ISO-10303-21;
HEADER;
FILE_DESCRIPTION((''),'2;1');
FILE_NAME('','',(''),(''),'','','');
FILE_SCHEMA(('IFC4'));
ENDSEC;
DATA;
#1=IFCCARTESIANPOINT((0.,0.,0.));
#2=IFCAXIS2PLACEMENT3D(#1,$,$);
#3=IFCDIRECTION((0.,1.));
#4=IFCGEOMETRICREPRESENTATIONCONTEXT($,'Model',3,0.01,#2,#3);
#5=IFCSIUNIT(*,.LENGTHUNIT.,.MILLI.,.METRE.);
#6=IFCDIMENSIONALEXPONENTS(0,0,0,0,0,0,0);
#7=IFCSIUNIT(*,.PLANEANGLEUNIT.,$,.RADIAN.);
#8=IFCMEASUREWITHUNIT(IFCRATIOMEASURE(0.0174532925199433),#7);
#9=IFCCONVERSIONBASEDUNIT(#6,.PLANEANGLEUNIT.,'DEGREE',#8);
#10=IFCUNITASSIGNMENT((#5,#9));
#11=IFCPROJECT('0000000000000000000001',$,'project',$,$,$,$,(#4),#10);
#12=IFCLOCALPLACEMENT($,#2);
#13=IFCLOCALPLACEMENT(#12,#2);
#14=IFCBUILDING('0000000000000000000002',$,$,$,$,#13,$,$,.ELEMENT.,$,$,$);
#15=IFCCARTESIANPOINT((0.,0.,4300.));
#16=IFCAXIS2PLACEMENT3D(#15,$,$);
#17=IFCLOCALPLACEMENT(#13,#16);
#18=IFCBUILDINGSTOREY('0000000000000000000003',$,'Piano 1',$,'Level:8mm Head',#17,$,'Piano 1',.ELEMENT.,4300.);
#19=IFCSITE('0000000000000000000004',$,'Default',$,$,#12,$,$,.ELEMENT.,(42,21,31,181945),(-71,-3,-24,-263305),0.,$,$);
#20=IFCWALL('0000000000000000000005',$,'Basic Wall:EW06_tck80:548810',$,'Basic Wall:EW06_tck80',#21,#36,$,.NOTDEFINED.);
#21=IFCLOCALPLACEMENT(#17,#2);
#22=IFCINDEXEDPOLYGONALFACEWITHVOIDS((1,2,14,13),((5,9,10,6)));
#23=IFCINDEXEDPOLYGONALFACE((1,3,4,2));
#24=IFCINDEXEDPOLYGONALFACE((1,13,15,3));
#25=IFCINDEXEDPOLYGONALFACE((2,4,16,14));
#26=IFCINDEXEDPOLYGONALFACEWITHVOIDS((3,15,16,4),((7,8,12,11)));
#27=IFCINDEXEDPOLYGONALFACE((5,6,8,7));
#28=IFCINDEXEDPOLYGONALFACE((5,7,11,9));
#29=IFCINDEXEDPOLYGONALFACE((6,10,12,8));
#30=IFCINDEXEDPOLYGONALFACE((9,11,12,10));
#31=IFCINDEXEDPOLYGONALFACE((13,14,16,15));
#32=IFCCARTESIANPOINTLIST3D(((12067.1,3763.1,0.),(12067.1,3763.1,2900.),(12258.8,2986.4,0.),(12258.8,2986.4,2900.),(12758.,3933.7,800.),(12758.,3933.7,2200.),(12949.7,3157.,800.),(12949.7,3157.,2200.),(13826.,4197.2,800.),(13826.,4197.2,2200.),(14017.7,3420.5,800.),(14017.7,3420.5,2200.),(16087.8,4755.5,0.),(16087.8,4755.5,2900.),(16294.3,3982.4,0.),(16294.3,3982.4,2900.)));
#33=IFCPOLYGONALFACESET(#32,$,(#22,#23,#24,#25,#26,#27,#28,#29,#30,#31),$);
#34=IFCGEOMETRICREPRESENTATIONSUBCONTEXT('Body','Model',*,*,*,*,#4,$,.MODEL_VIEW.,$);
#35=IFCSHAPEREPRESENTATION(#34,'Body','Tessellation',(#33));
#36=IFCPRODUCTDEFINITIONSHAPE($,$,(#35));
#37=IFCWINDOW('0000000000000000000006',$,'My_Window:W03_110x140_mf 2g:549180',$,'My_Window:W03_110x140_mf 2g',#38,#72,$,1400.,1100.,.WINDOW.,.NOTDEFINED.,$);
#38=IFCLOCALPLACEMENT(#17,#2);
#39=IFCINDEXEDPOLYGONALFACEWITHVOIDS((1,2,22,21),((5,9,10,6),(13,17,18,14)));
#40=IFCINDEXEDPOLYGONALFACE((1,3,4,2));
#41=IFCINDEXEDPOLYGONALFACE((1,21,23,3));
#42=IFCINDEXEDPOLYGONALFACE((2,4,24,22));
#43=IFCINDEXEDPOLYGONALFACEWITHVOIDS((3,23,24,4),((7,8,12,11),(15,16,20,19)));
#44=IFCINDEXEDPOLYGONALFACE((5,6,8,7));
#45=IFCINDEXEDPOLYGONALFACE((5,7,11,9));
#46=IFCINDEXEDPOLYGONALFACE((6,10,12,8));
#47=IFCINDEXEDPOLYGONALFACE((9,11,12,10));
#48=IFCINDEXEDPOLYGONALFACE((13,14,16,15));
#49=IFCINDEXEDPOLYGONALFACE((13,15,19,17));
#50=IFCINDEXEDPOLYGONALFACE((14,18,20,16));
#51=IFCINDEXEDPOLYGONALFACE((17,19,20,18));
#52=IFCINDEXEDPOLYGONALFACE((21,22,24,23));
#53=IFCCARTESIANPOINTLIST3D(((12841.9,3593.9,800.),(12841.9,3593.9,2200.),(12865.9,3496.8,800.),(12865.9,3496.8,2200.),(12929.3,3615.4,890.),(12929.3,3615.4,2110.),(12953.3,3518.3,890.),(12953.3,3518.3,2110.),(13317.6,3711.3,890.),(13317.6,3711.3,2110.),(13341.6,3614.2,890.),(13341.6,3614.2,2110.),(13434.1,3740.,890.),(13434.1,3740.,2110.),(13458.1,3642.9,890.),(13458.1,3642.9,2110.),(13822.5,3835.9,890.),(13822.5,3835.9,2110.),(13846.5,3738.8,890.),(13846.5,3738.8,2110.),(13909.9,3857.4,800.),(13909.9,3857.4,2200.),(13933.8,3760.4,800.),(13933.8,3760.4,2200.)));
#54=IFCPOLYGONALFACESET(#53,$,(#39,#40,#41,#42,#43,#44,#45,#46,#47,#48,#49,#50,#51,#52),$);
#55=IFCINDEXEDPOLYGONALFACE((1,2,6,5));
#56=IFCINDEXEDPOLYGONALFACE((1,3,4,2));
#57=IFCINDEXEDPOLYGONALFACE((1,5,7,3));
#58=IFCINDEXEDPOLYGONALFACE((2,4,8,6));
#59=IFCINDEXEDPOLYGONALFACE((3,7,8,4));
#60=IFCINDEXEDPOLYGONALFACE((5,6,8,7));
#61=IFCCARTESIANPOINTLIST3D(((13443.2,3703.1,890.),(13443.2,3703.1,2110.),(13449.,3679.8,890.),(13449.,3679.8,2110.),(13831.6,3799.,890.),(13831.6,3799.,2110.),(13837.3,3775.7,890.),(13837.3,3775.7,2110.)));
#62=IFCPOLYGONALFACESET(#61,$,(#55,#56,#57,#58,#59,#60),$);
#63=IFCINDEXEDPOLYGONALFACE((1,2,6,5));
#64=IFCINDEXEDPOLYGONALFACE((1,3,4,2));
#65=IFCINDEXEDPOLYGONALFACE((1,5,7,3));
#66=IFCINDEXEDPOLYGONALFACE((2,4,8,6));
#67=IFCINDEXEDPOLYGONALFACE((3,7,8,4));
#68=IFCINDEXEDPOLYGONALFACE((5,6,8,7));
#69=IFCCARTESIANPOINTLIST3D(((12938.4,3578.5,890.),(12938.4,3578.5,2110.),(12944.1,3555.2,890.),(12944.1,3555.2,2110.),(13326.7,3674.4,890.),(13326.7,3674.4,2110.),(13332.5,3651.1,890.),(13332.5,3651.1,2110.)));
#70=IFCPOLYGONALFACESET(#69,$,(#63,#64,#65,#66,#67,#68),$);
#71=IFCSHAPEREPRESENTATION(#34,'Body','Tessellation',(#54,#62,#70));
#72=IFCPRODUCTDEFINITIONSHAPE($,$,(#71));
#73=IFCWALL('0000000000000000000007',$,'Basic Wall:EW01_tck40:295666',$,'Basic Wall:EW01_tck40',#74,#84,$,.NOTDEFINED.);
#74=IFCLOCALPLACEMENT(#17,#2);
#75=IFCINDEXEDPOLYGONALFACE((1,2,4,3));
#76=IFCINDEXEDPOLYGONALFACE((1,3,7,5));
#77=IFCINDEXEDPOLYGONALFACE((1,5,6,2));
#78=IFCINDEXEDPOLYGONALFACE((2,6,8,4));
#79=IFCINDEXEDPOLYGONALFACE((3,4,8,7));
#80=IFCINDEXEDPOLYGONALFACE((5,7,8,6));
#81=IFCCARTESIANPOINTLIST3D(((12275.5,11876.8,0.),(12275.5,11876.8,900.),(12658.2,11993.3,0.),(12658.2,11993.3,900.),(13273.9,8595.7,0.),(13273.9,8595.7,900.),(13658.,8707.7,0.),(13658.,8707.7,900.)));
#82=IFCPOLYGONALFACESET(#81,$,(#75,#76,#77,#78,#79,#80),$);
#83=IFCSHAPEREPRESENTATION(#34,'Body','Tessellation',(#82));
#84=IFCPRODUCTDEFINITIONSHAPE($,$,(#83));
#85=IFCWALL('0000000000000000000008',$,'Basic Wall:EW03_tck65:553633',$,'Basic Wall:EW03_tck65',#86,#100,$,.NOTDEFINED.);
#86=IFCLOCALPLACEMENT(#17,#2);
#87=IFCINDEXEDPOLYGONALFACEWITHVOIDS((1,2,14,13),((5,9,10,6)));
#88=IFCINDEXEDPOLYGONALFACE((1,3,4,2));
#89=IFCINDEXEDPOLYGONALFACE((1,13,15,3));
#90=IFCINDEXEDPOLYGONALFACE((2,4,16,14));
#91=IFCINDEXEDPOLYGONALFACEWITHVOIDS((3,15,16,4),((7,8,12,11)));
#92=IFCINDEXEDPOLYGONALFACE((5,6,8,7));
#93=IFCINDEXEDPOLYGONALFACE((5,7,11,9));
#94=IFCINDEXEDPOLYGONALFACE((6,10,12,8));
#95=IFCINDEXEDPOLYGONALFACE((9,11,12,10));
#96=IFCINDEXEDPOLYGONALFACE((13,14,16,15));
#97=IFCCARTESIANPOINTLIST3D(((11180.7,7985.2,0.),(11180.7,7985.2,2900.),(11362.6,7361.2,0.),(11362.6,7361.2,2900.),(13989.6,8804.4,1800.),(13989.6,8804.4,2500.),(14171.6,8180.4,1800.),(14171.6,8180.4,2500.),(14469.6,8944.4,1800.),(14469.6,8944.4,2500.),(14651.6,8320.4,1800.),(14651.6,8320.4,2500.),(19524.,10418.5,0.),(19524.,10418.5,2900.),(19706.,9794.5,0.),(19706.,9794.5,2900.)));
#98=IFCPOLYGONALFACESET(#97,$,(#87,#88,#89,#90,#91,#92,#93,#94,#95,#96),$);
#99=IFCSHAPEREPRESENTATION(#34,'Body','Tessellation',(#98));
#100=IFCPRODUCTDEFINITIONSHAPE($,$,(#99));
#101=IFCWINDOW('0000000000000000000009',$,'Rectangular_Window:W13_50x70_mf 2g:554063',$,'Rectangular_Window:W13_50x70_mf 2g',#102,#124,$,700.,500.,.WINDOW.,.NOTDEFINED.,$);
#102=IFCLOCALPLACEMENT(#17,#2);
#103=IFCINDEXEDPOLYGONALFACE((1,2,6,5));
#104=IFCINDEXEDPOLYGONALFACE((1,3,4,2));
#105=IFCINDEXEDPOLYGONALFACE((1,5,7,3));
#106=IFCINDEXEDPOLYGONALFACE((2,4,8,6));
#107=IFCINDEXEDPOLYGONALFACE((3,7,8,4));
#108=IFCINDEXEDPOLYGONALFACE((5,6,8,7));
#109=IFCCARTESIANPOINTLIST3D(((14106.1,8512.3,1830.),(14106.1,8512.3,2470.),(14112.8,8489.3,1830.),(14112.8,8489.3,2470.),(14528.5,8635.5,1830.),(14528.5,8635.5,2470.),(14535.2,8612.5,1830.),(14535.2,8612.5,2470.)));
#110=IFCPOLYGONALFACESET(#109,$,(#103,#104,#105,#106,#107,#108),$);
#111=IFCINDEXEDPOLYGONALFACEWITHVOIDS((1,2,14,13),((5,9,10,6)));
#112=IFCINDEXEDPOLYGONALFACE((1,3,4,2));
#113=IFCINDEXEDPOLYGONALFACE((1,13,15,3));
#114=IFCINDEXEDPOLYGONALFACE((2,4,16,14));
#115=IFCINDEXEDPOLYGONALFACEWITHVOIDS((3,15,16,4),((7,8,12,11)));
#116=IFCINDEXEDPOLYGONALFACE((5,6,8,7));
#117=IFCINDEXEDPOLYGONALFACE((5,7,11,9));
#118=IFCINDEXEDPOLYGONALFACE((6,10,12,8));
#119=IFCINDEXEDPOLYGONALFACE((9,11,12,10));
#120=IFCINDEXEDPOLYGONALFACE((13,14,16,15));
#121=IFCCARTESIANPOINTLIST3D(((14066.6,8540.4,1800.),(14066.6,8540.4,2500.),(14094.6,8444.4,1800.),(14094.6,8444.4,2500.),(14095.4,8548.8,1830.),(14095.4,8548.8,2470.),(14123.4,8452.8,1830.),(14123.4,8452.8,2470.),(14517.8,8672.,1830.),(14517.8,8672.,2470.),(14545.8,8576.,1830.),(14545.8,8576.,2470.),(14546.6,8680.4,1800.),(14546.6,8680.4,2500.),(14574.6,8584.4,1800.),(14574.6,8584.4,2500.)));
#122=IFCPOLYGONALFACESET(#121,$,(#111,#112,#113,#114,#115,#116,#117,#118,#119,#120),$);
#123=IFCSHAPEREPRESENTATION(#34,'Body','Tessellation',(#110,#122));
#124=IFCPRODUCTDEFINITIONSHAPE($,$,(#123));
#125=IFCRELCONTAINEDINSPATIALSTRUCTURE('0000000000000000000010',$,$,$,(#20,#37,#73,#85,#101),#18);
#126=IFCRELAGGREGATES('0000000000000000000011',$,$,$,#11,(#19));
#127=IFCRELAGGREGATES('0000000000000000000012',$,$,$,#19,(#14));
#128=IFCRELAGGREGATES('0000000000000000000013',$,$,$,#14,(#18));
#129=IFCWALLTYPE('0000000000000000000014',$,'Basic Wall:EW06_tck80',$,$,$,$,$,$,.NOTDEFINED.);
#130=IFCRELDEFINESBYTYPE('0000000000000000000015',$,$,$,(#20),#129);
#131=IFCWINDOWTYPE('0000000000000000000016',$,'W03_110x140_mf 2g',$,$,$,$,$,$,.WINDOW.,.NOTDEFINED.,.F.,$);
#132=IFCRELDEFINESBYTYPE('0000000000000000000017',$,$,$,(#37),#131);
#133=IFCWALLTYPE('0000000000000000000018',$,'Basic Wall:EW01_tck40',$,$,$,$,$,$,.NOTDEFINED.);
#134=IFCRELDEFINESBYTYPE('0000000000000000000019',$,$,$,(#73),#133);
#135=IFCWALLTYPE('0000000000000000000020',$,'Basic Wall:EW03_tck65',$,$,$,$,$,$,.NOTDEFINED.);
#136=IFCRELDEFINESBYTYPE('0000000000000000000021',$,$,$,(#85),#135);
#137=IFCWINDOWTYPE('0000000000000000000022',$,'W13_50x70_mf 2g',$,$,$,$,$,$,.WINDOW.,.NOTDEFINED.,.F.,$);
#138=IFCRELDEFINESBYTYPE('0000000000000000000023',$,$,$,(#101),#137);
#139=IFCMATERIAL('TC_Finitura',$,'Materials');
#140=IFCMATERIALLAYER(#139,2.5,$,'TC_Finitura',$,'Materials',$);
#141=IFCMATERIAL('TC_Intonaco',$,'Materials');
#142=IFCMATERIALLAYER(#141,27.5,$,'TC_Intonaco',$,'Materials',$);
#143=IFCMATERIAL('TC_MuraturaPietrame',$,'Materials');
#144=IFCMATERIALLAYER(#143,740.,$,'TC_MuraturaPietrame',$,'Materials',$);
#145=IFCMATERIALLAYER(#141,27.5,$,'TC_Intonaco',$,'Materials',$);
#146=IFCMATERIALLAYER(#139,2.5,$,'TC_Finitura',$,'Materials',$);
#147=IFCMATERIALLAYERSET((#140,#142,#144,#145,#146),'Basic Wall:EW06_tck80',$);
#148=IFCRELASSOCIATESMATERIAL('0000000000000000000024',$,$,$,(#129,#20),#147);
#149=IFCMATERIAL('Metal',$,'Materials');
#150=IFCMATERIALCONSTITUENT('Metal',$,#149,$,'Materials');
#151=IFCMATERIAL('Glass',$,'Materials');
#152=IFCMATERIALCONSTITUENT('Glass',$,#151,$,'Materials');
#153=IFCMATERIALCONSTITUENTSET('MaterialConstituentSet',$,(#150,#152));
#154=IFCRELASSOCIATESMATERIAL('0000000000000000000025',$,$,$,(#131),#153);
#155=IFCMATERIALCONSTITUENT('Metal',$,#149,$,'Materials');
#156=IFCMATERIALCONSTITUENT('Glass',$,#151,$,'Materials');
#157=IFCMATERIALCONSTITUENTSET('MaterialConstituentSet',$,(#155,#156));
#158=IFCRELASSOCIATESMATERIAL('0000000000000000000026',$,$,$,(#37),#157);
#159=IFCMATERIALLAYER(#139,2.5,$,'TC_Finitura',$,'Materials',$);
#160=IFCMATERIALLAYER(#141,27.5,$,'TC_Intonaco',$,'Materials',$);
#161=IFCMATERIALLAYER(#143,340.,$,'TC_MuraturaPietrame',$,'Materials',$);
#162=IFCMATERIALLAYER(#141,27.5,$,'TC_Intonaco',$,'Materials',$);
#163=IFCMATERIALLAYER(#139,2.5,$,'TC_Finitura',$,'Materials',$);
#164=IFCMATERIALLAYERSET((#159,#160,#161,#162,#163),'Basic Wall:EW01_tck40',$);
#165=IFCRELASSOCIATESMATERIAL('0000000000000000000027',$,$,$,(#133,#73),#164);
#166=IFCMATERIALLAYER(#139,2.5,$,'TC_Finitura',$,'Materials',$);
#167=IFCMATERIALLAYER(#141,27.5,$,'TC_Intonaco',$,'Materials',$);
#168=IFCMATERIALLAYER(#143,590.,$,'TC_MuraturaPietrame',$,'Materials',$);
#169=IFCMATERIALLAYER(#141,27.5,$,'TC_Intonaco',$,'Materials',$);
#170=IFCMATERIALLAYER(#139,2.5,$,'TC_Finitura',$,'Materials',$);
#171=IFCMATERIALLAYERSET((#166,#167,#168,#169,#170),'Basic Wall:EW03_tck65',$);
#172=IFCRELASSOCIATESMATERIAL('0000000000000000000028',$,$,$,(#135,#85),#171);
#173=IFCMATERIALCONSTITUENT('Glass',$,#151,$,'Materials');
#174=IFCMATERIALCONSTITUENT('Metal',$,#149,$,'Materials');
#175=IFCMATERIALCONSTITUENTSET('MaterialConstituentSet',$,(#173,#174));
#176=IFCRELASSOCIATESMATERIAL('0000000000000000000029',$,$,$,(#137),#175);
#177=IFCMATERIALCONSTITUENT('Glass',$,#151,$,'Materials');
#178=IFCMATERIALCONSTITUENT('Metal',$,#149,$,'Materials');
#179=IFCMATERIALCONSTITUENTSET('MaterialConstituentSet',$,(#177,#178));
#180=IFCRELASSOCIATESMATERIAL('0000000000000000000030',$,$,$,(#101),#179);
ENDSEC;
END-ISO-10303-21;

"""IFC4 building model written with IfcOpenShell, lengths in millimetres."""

from ifc_helpers import new_model, entity, si_unit, converted_unit, direction, frame, frame_2d, origin, origin_2d_with_axis, place, context, subcontext, project, spatial, polyline, rectangle, outline, extrude, clip, bounded_halfspace, source, transform, mapped, material, layer, layer_set, layer_usage, constituent, constituent_set, type_object, type_shapes, element, fill, save


model = new_model("IFC4")

# Units and contexts
model_context = context("Model", 3, precision=0.01, world=origin(), true_north=direction((0.0, 1.0)))
body_context = subcontext(model_context, "Body", "Model", "MODEL_VIEW")
ifc_project = project(units=[si_unit("LENGTHUNIT", "METRE", prefix="MILLI"), converted_unit("PLANEANGLEUNIT", "DEGREE", entity("IfcRatioMeasure", 0.0174532925199433), si_unit("PLANEANGLEUNIT", "RADIAN"), dimensions=[0, 0, 0, 0, 0, 0, 0])], contexts=[model_context])

# Site, building, storey
site_placement = place(None, origin())
site = spatial("IfcSite", under=ifc_project, at=site_placement, Name="Default", CompositionType="ELEMENT", RefLatitude=(42, 21, 31, 181945), RefLongitude=(-71, -3, -24, -263305), RefElevation=0.0)
building_placement = place(site_placement, origin())
building = spatial("IfcBuilding", under=site, at=building_placement, CompositionType="ELEMENT")
storey_placement = place(building_placement, frame((0.0, 0.0, 4300.0)))
storey = spatial("IfcBuildingStorey", under=building, at=storey_placement, Name="Piano 1", ObjectType="Level:8mm Head", LongName="Piano 1", CompositionType="ELEMENT", Elevation=4300.0)

# Wall, opening, window
ifc_material_1 = material(Name="TC_Finitura", Category="Materials")
ifc_layer_1 = layer(ifc_material_1, 2.5, Name="TC_Finitura", Category="Materials")
ifc_material_2 = material(Name="TC_Intonaco", Category="Materials")
ifc_layer_2 = layer(ifc_material_2, 27.5, Name="TC_Intonaco", Category="Materials")
ifc_material_3 = material(Name="TC_MuraturaPietrame", Category="Materials")
ifc_layer_3 = layer(ifc_material_3, 740.0, Name="TC_MuraturaPietrame", Category="Materials")
ifc_layer_4 = layer(ifc_material_2, 27.5, Name="TC_Intonaco", Category="Materials")
ifc_layer_5 = layer(ifc_material_1, 2.5, Name="TC_Finitura", Category="Materials")
ifc_layer_set_1 = layer_set([ifc_layer_1, ifc_layer_2, ifc_layer_3, ifc_layer_4, ifc_layer_5], Name="Basic Wall:EW06_tck80")
ifc_layer_usage_1 = layer_usage(ifc_layer_set_1, "AXIS2", "NEGATIVE", 400.0)
wall_type_1 = type_object("IfcWallType", Name="Basic Wall:EW06_tck80", PredefinedType="NOTDEFINED", material=ifc_layer_set_1)
wall_1_placement = place(storey_placement, frame((16198.4, 4370.8, 0.0), z_axis=(0.0, 0.0, 1.0), x_axis=(-0.970868, -0.239617, 0.0)))
wall_1 = element("IfcWall", 1, at=wall_1_placement, inside=storey, type_object=wall_type_1, material=ifc_layer_usage_1, Name="Basic Wall:EW06_tck80:548810", ObjectType="Basic Wall:EW06_tck80", PredefinedType="NOTDEFINED", context=body_context, shape_type="Clipping", body=[
    clip(extrude(outline(polyline([(4156.6, -400.0), (4156.6, 400.0), (0.0, 400.0), (14.0, -333.4), (15.3, -400.0), (4156.6, -400.0)])), origin(), (0.0, 0.0, 1.0), 2900.0), bounded_halfspace(frame((15.3, -400.0, 2900.0), z_axis=(0.0, 0.0, -1.0), x_axis=(-0.999481, -0.032214, 0.0)), True, frame((15.3, -400.0, 2900.0)), polyline([(0.0, 0.0), (4141.3, 0.0), (4141.3, 800.0), (-15.3, 800.0), (-1.3, 66.6), (0.0, 0.0)]))),
])
opening_1_placement = place(wall_1_placement, frame((2344.9, -400.0, 800.0)))
opening_1 = element("IfcOpeningElement", 2, at=opening_1_placement, cuts=wall_1, ObjectType="Opening", PredefinedType="OPENING", context=body_context, shape_type="SweptSolid", body=[
    extrude(rectangle(XDim=1400.0, YDim=1100.0, at=frame_2d((700.0, 550.0), x_axis=(-1.0, 0.0))), frame((0.0, 0.0, 0.0), z_axis=(0.0, 1.0, 0.0), x_axis=(0.0, 0.0, 1.0)), (0.0, 0.0, 1.0), 800.0),
])
ifc_material_4 = material(Name="Metal", Category="Materials")
ifc_constituent_1 = constituent(ifc_material_4, Name="Metal", Category="Materials")
ifc_material_5 = material(Name="Glass", Category="Materials")
ifc_constituent_2 = constituent(ifc_material_5, Name="Glass", Category="Materials")
ifc_constituent_set_1 = constituent_set(constituents=[ifc_constituent_1, ifc_constituent_2], Name="MaterialConstituentSet")
ifc_constituent_3 = constituent(ifc_material_4, Name="Metal", Category="Materials")
ifc_constituent_4 = constituent(ifc_material_5, Name="Glass", Category="Materials")
ifc_constituent_set_2 = constituent_set(constituents=[ifc_constituent_3, ifc_constituent_4], Name="MaterialConstituentSet")
window_type_1 = type_object("IfcWindowType", Name="W03_110x140_mf 2g", ParameterTakesPrecedence=False, PartitioningType="NOTDEFINED", PredefinedType="WINDOW", material=ifc_constituent_set_2)
shared_shape_1 = source(origin(), body_context, "Body", "SweptSolid", [
    extrude(outline(polyline([(-550.0, -700.0), (550.0, -700.0), (550.0, 700.0), (-550.0, 700.0), (-550.0, -700.0)]), holes=[polyline([(-60.0, -610.0), (-460.0, -610.0), (-460.0, 610.0), (-60.0, 610.0), (-60.0, -610.0)]), polyline([(460.0, -610.0), (60.0, -610.0), (60.0, 610.0), (460.0, 610.0), (460.0, -610.0)])]), frame((550.0, 350.0, 700.0), z_axis=(0.0, 1.0, 0.0), x_axis=(1.0, 0.0, 0.0)), (0.0, 0.0, 1.0), 100.0),
    extrude(rectangle(XDim=24.0, YDim=400.0, at=origin_2d_with_axis()), frame((290.0, 400.0, 90.0), z_axis=(0.0, 0.0, 1.0), x_axis=(0.0, 1.0, 0.0)), (0.0, 0.0, 1.0), 1220.0),
    extrude(rectangle(XDim=24.0, YDim=400.0, at=frame_2d((0.0, 0.0), x_axis=(1.0, 0.0))), frame((810.0, 400.0, 90.0), z_axis=(0.0, 0.0, 1.0), x_axis=(0.0, 1.0, 0.0)), (0.0, 0.0, 1.0), 1220.0),
])
type_shapes(window_type_1, [shared_shape_1])
window_1_placement = place(opening_1_placement, origin())
window_1 = element("IfcWindow", 3, at=window_1_placement, inside=storey, type_object=window_type_1, material=ifc_constituent_set_1, Name="My_Window:W03_110x140_mf 2g:549180", ObjectType="My_Window:W03_110x140_mf 2g", OverallHeight=1400.0, OverallWidth=1100.0, PartitioningType="NOTDEFINED", PredefinedType="WINDOW", context=body_context, shape_type="MappedRepresentation", body=[
    mapped(shared_shape_1, transform((0.0, 0.0, 0.0), scale=1.0)),
])
fill(opening_1, window_1)

# Wall
ifc_layer_6 = layer(ifc_material_1, 2.5, Name="TC_Finitura", Category="Materials")
ifc_layer_7 = layer(ifc_material_2, 27.5, Name="TC_Intonaco", Category="Materials")
ifc_layer_8 = layer(ifc_material_3, 340.0, Name="TC_MuraturaPietrame", Category="Materials")
ifc_layer_9 = layer(ifc_material_2, 27.5, Name="TC_Intonaco", Category="Materials")
ifc_layer_10 = layer(ifc_material_1, 2.5, Name="TC_Finitura", Category="Materials")
ifc_layer_set_2 = layer_set([ifc_layer_6, ifc_layer_7, ifc_layer_8, ifc_layer_9, ifc_layer_10], Name="Basic Wall:EW01_tck40")
ifc_layer_usage_2 = layer_usage(ifc_layer_set_2, "AXIS2", "NEGATIVE", 200.0)
wall_type_2 = type_object("IfcWallType", Name="Basic Wall:EW01_tck40", PredefinedType="NOTDEFINED", material=ifc_layer_set_2)
wall_2_placement = place(storey_placement, frame((13466.6, 8649.5, 0.0), z_axis=(0.0, 0.0, 1.0), x_axis=(-0.291111, 0.956689, 0.0)))
element("IfcWall", 4, at=wall_2_placement, inside=storey, type_object=wall_type_2, material=ifc_layer_usage_2, Name="Basic Wall:EW01_tck40:295666", ObjectType="Basic Wall:EW01_tck40", PredefinedType="NOTDEFINED", context=body_context, shape_type="SweptSolid", body=[
    extrude(outline(polyline([(3434.3, -200.0), (3434.3, 200.0), (4.6, 200.0), (0.0, -200.0), (3434.3, -200.0)])), origin(), (0.0, 0.0, 1.0), 900.0),
])

# Wall, opening, window
ifc_layer_11 = layer(ifc_material_1, 2.5, Name="TC_Finitura", Category="Materials")
ifc_layer_12 = layer(ifc_material_2, 27.5, Name="TC_Intonaco", Category="Materials")
ifc_layer_13 = layer(ifc_material_3, 590.0, Name="TC_MuraturaPietrame", Category="Materials")
ifc_layer_14 = layer(ifc_material_2, 27.5, Name="TC_Intonaco", Category="Materials")
ifc_layer_15 = layer(ifc_material_1, 2.5, Name="TC_Finitura", Category="Materials")
ifc_layer_set_3 = layer_set([ifc_layer_11, ifc_layer_12, ifc_layer_13, ifc_layer_14, ifc_layer_15], Name="Basic Wall:EW03_tck65")
ifc_layer_usage_3 = layer_usage(ifc_layer_set_3, "AXIS2", "NEGATIVE", 325.0)
wall_type_3 = type_object("IfcWallType", Name="Basic Wall:EW03_tck65", PredefinedType="NOTDEFINED", material=ifc_layer_set_3)
wall_3_placement = place(storey_placement, frame((11271.7, 7673.2, 0.0), z_axis=(0.0, 0.0, 1.0), x_axis=(0.960008, 0.279974, 0.0)))
wall_3 = element("IfcWall", 5, at=wall_3_placement, inside=storey, type_object=wall_type_3, material=ifc_layer_usage_3, Name="Basic Wall:EW03_tck65:553633", ObjectType="Basic Wall:EW03_tck65", PredefinedType="NOTDEFINED", context=body_context, shape_type="Clipping", body=[
    clip(extrude(rectangle(XDim=8690.9, YDim=650.0, at=frame_2d((4345.5, 0.0), x_axis=(-1.0, 0.0))), origin(), (0.0, 0.0, 1.0), 2900.0), bounded_halfspace(frame((0.0, -325.0, 2900.0), z_axis=(0.0, 0.0, -1.0), x_axis=(0.999954, -0.009577, 0.0)), True, frame((0.0, -325.0, 2900.0)), polyline([(0.0, 0.0), (3893.5, 0.0), (4293.6, 0.0), (8690.9, 0.0), (8690.9, 242.6), (8690.9, 650.0), (2533.6, 650.0), (2133.6, 650.0), (37.0, 650.0), (0.0, 650.0), (0.0, 0.0)]))),
])
opening_2_placement = place(wall_3_placement, frame((3426.0, 325.0, 1800.0)))
opening_2 = element("IfcOpeningElement", 6, at=opening_2_placement, cuts=wall_3, ObjectType="Opening", PredefinedType="OPENING", context=body_context, shape_type="SweptSolid", body=[
    extrude(rectangle(XDim=700.0, YDim=500.0, at=frame_2d((350.0, 250.0), x_axis=(-1.0, 0.0))), frame((0.0, 0.0, 0.0), z_axis=(0.0, -1.0, 0.0), x_axis=(0.0, 0.0, 1.0)), (0.0, 0.0, 1.0), 650.0),
])
ifc_constituent_5 = constituent(ifc_material_5, Name="Glass", Category="Materials")
ifc_constituent_6 = constituent(ifc_material_4, Name="Metal", Category="Materials")
ifc_constituent_set_3 = constituent_set(constituents=[ifc_constituent_5, ifc_constituent_6], Name="MaterialConstituentSet")
ifc_constituent_7 = constituent(ifc_material_5, Name="Glass", Category="Materials")
ifc_constituent_8 = constituent(ifc_material_4, Name="Metal", Category="Materials")
ifc_constituent_set_4 = constituent_set(constituents=[ifc_constituent_7, ifc_constituent_8], Name="MaterialConstituentSet")
window_type_2 = type_object("IfcWindowType", Name="W13_50x70_mf 2g", ParameterTakesPrecedence=False, PartitioningType="NOTDEFINED", PredefinedType="WINDOW", material=ifc_constituent_set_4)
shared_shape_2 = source(origin(), body_context, "Body", "SweptSolid", [
    extrude(rectangle(XDim=24.0, YDim=440.0, at=origin_2d_with_axis()), frame((250.0, 325.0, 30.0), z_axis=(0.0, 0.0, 1.0), x_axis=(0.0, 1.0, 0.0)), (0.0, 0.0, 1.0), 640.0),
    extrude(outline(polyline([(-250.0, -350.0), (250.0, -350.0), (250.0, 350.0), (-250.0, 350.0), (-250.0, -350.0)]), holes=[polyline([(-220.0, -320.0), (-220.0, 320.0), (220.0, 320.0), (220.0, -320.0), (-220.0, -320.0)])]), frame((250.0, 275.0, 350.0), z_axis=(0.0, 1.0, 0.0), x_axis=(1.0, 0.0, 0.0)), (0.0, 0.0, 1.0), 100.0),
])
type_shapes(window_type_2, [shared_shape_2])
window_2_placement = place(opening_2_placement, frame((0.0, 0.0, 0.0), z_axis=(0.0, 0.0, 1.0), x_axis=(-1.0, 0.0, 0.0)))
window_2 = element("IfcWindow", 7, at=window_2_placement, inside=storey, type_object=window_type_2, material=ifc_constituent_set_3, Name="Rectangular_Window:W13_50x70_mf 2g:554063", ObjectType="Rectangular_Window:W13_50x70_mf 2g", OverallHeight=700.0, OverallWidth=500.0, PartitioningType="NOTDEFINED", PredefinedType="WINDOW", context=body_context, shape_type="MappedRepresentation", body=[
    mapped(shared_shape_2, transform((0.0, 0.0, 0.0), scale=1.0)),
])
fill(opening_2, window_2)

save(model, "model.ifc")
